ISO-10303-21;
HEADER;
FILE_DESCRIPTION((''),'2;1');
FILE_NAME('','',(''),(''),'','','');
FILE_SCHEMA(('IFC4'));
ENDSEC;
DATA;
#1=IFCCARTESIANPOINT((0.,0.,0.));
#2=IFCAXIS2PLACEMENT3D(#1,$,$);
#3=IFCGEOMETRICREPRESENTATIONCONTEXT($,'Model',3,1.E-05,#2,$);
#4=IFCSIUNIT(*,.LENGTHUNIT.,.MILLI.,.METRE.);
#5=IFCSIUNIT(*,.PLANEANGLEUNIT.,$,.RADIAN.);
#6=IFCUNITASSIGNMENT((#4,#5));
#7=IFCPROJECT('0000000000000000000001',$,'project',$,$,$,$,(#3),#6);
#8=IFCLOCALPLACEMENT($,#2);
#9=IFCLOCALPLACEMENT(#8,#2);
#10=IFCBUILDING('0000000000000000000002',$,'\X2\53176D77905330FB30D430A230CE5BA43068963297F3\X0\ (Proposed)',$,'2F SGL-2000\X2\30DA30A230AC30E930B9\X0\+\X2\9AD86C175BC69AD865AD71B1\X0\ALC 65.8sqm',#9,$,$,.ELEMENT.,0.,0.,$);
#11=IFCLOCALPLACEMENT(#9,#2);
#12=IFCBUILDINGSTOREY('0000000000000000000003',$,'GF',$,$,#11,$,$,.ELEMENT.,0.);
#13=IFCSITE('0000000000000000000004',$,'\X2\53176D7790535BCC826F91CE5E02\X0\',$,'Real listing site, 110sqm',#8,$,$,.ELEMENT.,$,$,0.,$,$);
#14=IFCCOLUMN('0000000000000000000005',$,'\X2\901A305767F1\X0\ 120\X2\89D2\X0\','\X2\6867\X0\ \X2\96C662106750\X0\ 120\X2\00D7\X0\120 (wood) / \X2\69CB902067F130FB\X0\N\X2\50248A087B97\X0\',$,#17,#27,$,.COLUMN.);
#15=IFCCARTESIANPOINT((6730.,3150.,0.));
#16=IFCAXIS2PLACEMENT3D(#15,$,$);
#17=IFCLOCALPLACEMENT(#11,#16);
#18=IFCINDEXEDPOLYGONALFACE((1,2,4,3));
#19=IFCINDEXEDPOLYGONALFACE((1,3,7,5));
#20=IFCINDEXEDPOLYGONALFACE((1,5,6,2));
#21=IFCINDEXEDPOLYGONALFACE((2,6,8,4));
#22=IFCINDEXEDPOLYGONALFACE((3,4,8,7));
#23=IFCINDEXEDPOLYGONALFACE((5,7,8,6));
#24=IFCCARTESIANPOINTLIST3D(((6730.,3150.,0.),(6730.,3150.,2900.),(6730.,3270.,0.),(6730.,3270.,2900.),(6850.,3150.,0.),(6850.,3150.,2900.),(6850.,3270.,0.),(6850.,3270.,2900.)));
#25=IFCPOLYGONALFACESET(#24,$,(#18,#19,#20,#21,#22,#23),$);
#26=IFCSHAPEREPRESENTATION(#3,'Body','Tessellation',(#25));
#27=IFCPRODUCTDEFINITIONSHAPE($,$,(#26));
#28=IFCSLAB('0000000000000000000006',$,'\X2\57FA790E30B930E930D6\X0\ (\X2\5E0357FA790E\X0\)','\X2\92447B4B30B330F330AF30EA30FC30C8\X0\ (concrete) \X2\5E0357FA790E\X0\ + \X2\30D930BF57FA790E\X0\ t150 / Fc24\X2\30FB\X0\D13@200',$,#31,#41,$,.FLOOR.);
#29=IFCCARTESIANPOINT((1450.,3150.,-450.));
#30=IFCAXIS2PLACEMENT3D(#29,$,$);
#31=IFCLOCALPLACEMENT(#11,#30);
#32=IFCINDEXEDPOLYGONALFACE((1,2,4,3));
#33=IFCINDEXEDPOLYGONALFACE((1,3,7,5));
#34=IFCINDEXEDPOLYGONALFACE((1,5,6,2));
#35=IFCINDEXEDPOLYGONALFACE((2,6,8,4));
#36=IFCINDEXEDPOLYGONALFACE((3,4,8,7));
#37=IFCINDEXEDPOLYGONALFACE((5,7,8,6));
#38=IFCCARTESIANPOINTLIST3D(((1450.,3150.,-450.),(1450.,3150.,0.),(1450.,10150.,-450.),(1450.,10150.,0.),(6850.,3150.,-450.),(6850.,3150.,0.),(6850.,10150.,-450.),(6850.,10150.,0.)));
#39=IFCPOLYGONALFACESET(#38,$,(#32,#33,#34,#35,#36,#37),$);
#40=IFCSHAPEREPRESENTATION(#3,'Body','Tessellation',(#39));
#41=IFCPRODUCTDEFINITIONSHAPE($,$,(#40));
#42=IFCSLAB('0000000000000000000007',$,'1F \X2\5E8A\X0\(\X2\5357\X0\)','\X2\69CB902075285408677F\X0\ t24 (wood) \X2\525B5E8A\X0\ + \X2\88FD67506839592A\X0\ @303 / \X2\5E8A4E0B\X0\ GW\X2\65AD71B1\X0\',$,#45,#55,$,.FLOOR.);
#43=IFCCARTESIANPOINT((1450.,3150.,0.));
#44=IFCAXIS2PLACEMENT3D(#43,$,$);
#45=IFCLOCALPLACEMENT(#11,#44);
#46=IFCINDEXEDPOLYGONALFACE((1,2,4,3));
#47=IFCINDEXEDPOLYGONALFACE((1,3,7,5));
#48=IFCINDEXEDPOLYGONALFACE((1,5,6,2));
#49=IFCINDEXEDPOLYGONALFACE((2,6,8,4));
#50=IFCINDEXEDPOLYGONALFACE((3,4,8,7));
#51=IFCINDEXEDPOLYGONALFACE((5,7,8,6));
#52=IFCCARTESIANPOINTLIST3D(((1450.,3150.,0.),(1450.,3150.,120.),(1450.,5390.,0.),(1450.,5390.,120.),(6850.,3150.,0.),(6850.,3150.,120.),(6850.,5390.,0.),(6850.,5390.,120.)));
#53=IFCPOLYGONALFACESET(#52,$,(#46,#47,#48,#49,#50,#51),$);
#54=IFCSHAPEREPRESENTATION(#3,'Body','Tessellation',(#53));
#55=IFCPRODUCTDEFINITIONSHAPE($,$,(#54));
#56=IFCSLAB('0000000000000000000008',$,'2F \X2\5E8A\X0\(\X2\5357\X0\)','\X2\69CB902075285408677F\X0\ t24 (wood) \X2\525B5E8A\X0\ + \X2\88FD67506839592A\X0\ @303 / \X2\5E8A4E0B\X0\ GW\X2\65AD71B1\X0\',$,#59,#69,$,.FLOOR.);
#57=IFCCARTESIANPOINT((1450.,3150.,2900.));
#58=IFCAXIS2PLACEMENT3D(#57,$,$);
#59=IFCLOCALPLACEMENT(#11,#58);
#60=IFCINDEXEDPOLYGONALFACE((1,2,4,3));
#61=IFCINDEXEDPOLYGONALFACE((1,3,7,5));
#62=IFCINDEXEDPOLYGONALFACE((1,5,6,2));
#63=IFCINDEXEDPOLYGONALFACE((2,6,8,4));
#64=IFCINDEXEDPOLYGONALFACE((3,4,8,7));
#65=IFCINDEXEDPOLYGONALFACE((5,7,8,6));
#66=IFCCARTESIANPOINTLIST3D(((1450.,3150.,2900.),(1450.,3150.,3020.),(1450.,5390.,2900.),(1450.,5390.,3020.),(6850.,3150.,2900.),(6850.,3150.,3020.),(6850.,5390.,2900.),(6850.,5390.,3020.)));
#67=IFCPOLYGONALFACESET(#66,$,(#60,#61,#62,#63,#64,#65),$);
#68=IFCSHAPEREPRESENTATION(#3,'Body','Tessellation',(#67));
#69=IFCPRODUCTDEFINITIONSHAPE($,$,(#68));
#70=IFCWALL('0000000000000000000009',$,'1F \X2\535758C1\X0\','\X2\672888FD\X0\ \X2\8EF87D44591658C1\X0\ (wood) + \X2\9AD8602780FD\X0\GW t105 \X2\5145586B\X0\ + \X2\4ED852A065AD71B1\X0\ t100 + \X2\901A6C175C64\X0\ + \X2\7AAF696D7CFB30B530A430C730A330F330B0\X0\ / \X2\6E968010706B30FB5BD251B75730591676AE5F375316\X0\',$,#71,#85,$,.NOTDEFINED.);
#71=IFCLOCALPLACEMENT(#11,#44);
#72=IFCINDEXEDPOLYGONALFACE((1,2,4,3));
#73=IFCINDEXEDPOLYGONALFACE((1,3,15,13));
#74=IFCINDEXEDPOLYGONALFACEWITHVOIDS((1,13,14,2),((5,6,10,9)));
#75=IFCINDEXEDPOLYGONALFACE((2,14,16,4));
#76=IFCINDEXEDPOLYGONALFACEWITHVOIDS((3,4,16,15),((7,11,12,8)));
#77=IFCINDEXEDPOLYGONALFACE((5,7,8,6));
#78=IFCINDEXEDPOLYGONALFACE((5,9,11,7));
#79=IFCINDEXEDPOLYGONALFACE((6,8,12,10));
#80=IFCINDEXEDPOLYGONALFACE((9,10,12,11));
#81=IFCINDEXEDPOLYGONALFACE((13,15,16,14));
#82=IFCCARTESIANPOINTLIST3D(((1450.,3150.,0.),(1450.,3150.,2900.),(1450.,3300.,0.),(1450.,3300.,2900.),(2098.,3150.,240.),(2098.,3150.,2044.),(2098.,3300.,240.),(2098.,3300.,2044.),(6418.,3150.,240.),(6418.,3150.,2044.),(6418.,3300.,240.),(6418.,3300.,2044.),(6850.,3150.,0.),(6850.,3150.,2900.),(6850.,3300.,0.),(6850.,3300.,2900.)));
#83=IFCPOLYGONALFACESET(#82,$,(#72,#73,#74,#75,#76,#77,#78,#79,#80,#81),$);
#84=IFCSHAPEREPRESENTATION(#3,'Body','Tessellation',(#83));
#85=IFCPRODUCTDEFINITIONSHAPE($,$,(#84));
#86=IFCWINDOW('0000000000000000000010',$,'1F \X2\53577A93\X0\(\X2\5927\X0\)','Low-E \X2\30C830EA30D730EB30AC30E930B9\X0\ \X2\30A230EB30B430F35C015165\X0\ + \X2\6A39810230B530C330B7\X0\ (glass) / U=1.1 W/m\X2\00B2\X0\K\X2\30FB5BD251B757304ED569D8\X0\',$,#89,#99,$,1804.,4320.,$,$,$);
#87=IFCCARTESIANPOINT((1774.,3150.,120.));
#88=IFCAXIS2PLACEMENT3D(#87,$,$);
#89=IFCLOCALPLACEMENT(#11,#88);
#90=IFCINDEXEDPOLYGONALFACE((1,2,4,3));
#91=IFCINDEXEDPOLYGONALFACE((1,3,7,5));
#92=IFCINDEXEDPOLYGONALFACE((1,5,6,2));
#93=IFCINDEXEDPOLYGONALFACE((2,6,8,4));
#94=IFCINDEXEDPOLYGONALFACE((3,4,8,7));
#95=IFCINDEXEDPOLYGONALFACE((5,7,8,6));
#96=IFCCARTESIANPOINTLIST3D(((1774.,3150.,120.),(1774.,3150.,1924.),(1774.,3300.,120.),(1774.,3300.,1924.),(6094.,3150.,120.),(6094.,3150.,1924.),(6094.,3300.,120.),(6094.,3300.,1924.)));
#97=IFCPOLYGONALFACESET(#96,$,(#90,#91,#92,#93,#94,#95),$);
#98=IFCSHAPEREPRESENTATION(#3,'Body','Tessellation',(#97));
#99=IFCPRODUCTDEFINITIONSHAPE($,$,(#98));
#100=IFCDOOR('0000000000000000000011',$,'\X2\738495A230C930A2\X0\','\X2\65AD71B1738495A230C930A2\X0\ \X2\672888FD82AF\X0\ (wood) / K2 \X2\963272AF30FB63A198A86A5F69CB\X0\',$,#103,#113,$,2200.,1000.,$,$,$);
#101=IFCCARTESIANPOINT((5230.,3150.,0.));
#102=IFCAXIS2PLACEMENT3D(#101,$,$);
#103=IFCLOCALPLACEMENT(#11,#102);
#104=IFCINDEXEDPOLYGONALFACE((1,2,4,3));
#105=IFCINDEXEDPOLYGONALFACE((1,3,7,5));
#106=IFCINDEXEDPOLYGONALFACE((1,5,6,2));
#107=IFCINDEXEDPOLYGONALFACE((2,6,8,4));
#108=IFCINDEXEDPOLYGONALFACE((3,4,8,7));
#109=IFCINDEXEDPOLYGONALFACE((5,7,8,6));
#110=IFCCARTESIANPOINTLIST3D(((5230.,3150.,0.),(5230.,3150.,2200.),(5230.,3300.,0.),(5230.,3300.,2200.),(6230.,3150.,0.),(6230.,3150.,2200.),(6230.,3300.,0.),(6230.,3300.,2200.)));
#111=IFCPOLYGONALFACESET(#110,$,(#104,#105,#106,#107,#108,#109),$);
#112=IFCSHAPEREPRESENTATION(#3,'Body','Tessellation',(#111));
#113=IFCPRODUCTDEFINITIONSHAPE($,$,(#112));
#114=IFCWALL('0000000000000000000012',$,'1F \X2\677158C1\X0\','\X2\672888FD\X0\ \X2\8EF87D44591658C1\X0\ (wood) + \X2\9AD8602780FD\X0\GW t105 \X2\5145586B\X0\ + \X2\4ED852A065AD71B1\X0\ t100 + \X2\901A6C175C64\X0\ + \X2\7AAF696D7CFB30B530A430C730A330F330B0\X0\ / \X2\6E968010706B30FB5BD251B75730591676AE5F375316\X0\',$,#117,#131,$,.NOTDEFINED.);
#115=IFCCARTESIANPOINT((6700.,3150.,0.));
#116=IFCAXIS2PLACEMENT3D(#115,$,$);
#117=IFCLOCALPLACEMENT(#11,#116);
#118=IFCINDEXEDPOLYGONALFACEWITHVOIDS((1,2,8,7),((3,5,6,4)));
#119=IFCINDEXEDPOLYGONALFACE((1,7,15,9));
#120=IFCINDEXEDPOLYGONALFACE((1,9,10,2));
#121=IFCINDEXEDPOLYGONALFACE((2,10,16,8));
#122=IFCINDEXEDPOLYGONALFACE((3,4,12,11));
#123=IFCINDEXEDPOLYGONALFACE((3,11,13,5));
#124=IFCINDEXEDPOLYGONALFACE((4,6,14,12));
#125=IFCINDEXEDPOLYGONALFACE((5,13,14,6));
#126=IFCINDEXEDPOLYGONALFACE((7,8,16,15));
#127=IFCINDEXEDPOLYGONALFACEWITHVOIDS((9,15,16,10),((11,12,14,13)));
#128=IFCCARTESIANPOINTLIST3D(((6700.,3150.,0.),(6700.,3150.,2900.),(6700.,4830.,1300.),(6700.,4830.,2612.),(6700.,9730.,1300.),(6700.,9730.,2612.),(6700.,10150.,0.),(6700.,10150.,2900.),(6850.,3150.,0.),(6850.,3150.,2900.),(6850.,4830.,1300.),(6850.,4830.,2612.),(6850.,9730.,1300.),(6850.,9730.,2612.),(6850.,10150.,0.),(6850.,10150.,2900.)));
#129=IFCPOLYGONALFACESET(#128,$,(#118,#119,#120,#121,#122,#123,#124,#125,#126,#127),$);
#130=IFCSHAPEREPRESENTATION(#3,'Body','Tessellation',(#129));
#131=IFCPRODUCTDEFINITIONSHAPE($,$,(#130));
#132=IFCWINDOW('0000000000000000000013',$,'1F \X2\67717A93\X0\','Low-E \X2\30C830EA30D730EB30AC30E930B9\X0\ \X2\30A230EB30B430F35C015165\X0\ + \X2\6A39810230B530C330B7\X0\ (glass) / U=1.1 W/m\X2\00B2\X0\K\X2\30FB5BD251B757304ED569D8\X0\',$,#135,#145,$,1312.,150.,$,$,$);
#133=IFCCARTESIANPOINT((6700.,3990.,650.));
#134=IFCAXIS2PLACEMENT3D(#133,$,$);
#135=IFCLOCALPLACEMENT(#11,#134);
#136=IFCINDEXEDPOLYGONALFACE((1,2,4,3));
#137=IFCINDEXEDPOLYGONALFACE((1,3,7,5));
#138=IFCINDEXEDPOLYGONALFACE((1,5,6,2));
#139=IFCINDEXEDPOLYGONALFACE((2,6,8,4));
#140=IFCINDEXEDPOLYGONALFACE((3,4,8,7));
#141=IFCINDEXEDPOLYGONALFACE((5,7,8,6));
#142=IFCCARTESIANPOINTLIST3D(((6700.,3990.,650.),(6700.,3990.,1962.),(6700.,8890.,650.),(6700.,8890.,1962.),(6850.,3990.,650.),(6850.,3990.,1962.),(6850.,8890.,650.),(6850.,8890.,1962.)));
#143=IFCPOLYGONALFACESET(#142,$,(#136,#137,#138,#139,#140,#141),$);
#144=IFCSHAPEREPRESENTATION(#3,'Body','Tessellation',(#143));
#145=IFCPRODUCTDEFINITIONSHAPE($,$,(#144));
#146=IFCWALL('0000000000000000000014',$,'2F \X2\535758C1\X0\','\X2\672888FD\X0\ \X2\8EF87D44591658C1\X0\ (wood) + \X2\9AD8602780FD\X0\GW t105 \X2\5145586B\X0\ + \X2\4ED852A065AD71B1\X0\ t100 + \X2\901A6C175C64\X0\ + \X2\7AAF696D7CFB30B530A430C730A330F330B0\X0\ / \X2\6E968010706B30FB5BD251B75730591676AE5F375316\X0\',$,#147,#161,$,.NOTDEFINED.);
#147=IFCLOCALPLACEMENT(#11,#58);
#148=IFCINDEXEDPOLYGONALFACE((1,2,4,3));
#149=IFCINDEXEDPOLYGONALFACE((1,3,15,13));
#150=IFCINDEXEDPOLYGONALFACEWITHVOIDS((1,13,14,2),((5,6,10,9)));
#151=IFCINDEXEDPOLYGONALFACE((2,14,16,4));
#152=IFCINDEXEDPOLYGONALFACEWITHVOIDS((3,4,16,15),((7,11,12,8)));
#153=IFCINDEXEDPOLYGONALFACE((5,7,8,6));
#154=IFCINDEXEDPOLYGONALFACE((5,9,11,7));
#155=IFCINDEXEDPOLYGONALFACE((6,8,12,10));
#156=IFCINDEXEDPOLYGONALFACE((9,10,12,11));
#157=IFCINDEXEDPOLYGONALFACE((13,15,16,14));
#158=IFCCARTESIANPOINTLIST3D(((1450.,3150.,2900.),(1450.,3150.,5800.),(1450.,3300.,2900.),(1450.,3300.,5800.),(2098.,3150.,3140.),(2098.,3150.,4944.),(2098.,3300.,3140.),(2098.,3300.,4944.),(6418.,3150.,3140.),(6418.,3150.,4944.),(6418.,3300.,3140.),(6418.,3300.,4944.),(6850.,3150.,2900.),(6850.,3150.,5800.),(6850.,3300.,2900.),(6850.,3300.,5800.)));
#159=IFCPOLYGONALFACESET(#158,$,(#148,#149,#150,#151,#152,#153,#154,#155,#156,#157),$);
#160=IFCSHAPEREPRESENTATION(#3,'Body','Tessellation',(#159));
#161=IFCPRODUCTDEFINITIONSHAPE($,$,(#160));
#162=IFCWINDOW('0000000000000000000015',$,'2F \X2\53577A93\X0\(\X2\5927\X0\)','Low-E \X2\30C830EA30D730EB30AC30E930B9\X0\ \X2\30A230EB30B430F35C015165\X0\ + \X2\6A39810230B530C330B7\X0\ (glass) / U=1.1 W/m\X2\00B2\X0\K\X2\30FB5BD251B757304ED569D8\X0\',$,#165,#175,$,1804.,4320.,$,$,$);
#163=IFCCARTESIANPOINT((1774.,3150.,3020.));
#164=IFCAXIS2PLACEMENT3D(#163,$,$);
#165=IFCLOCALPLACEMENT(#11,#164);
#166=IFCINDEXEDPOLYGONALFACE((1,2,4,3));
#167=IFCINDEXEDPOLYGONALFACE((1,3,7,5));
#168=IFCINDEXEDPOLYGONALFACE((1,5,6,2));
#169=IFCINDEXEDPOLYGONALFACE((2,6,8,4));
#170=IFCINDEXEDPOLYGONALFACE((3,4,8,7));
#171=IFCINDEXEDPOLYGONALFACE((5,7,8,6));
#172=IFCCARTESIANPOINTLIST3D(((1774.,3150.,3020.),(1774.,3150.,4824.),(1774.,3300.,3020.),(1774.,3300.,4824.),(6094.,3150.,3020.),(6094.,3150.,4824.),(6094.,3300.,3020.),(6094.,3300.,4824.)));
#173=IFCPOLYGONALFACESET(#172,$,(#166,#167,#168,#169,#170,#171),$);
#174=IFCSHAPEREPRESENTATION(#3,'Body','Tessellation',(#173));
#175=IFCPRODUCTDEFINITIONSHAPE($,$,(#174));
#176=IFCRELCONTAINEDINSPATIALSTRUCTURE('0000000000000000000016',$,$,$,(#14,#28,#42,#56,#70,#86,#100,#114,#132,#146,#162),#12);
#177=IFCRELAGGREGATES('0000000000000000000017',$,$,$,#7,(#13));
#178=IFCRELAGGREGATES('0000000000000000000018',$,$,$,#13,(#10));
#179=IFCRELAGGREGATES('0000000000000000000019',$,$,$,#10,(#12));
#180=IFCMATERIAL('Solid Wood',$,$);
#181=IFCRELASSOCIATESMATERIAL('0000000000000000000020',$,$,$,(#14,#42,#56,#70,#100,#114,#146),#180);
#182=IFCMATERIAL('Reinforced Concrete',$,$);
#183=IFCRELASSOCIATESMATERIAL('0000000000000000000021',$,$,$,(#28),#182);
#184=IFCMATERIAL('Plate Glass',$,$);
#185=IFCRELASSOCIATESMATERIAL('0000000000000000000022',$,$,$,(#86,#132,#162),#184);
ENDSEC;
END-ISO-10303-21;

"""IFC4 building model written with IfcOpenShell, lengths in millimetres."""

from ifc_helpers import new_model, si_unit, frame, frame_2d, origin, place, context, project, spatial, rectangle, extrude, material, element, fill, save


model = new_model("IFC4")

# Units and contexts
model_context = context("Model", 3, precision=1e-05, world=origin())
ifc_project = project(units=[si_unit("LENGTHUNIT", "METRE", prefix="MILLI"), si_unit("PLANEANGLEUNIT", "RADIAN")], contexts=[model_context])

# Site, building, storey
site_placement = place(None, origin())
site = spatial("IfcSite", under=ifc_project, at=site_placement, Name="北海道富良野市", ObjectType="Real listing site, 110sqm", CompositionType="ELEMENT", RefElevation=0.0)
building_placement = place(site_placement, origin())
building = spatial("IfcBuilding", under=site, at=building_placement, Name="北海道・ピアノ室と防音 (Proposed)", ObjectType="2F SGL-2000ペアガラス+高気密高断熱ALC 65.8sqm", CompositionType="ELEMENT", ElevationOfRefHeight=0.0, ElevationOfTerrain=0.0)
storey_placement = place(building_placement, origin())
storey = spatial("IfcBuildingStorey", under=building, at=storey_placement, Name="GF", CompositionType="ELEMENT", Elevation=0.0)

# Column
ifc_material_1 = material(Name="Solid Wood")
column_1_placement = place(storey_placement, frame((6730.0, 3150.0, 0.0)))
element("IfcColumn", 1, at=column_1_placement, inside=storey, material=ifc_material_1, Name="通し柱 120角", Description="桧 集成材 120×120 (wood) / 構造柱・N値計算", PredefinedType="COLUMN", context=model_context, shape_type="SweptSolid", body=[
    extrude(rectangle(XDim=120.0, YDim=120.0, at=frame_2d((60.0, 60.0))), frame((6730.0, 3150.0, 0.0)), (0.0, 0.0, 1.0), 2900.0),
])

# Slabs
ifc_material_2 = material(Name="Reinforced Concrete")
slab_1_placement = place(storey_placement, frame((1450.0, 3150.0, -450.0)))
element("IfcSlab", 2, at=slab_1_placement, inside=storey, material=ifc_material_2, Name="基礎スラブ (布基礎)", Description="鉄筋コンクリート (concrete) 布基礎 + ベタ基礎 t150 / Fc24・D13@200", PredefinedType="FLOOR", context=model_context, shape_type="SweptSolid", body=[
    extrude(rectangle(XDim=5400.0, YDim=7000.0, at=frame_2d((2700.0, 3500.0))), frame((1450.0, 3150.0, -450.0)), (0.0, 0.0, 1.0), 450.0),
])
slab_2_placement = place(storey_placement, frame((1450.0, 3150.0, 0.0)))
element("IfcSlab", 3, at=slab_2_placement, inside=storey, material=ifc_material_1, Name="1F 床(南)", Description="構造用合板 t24 (wood) 剛床 + 製材根太 @303 / 床下 GW断熱", PredefinedType="FLOOR", context=model_context, shape_type="SweptSolid", body=[
    extrude(rectangle(XDim=5400.0, YDim=2240.0, at=frame_2d((2700.0, 1120.0))), frame((1450.0, 3150.0, 0.0)), (0.0, 0.0, 1.0), 120.0),
])
slab_3_placement = place(storey_placement, frame((1450.0, 3150.0, 2900.0)))
element("IfcSlab", 4, at=slab_3_placement, inside=storey, material=ifc_material_1, Name="2F 床(南)", Description="構造用合板 t24 (wood) 剛床 + 製材根太 @303 / 床下 GW断熱", PredefinedType="FLOOR", context=model_context, shape_type="SweptSolid", body=[
    extrude(rectangle(XDim=5400.0, YDim=2240.0, at=frame_2d((2700.0, 1120.0))), frame((1450.0, 3150.0, 2900.0)), (0.0, 0.0, 1.0), 120.0),
])

# Wall, openings, window, door
wall_1_placement = place(storey_placement, frame((1450.0, 3150.0, 0.0)))
wall_1 = element("IfcWall", 5, at=wall_1_placement, inside=storey, material=ifc_material_1, Name="1F 南壁", Description="木製 軸組外壁 (wood) + 高性能GW t105 充填 + 付加断熱 t100 + 通気層 + 窯業系サイディング / 準耐火・寒冷地外皮強化", PredefinedType="NOTDEFINED", context=model_context, shape_type="SweptSolid", body=[
    extrude(rectangle(XDim=5400.0, YDim=150.0, at=frame_2d((2700.0, 75.0))), frame((1450.0, 3150.0, 0.0)), (0.0, 0.0, 1.0), 2900.0),
])
opening_1_placement = place(storey_placement, frame((1774.0, 3150.0, 120.0)))
opening_1 = element("IfcOpeningElement", 6, at=opening_1_placement, cuts=wall_1, PredefinedType="NOTDEFINED", context=model_context, shape_type="SweptSolid", body=[
    extrude(rectangle(XDim=4320.0, YDim=150.0, at=frame_2d((2160.0, 75.0))), frame((1774.0, 3150.0, 120.0)), (0.0, 0.0, 1.0), 1804.0),
])
opening_2_placement = place(storey_placement, frame((5230.0, 3150.0, 0.0)))
opening_2 = element("IfcOpeningElement", 7, at=opening_2_placement, cuts=wall_1, PredefinedType="NOTDEFINED", context=model_context, shape_type="SweptSolid", body=[
    extrude(rectangle(XDim=1000.0, YDim=150.0, at=frame_2d((500.0, 75.0))), frame((5230.0, 3150.0, 0.0)), (0.0, 0.0, 1.0), 2200.0),
])
ifc_material_3 = material(Name="Plate Glass")
window_1_placement = place(storey_placement, frame((1774.0, 3150.0, 120.0)))
window_1 = element("IfcWindow", 8, at=window_1_placement, inside=storey, material=ifc_material_3, Name="1F 南窓(大)", Description="Low-E トリプルガラス アルゴン封入 + 樹脂サッシ (glass) / U=1.1 W/m²K・寒冷地仕様", OverallHeight=1804.0, OverallWidth=4320.0, context=model_context, shape_type="SweptSolid", body=[
    extrude(rectangle(XDim=4320.0, YDim=150.0, at=frame_2d((2160.0, 75.0))), frame((1774.0, 3150.0, 120.0)), (0.0, 0.0, 1.0), 1804.0),
])
fill(opening_1, window_1)
door_placement = place(storey_placement, frame((5230.0, 3150.0, 0.0)))
door = element("IfcDoor", 9, at=door_placement, inside=storey, material=ifc_material_1, Name="玄関ドア", Description="断熱玄関ドア 木製芯 (wood) / K2 防犯・採風機構", OverallHeight=2200.0, OverallWidth=1000.0, context=model_context, shape_type="SweptSolid", body=[
    extrude(rectangle(XDim=1000.0, YDim=150.0, at=frame_2d((500.0, 75.0))), frame((5230.0, 3150.0, 0.0)), (0.0, 0.0, 1.0), 2200.0),
])
fill(opening_2, door)

# Walls, openings, windows
wall_2_placement = place(storey_placement, frame((6700.0, 3150.0, 0.0)))
wall_2 = element("IfcWall", 10, at=wall_2_placement, inside=storey, material=ifc_material_1, Name="1F 東壁", Description="木製 軸組外壁 (wood) + 高性能GW t105 充填 + 付加断熱 t100 + 通気層 + 窯業系サイディング / 準耐火・寒冷地外皮強化", PredefinedType="NOTDEFINED", context=model_context, shape_type="SweptSolid", body=[
    extrude(rectangle(XDim=150.0, YDim=7000.0, at=frame_2d((75.0, 3500.0))), frame((6700.0, 3150.0, 0.0)), (0.0, 0.0, 1.0), 2900.0),
])
opening_3_placement = place(storey_placement, frame((6700.0, 3990.0, 650.0)))
opening_3 = element("IfcOpeningElement", 11, at=opening_3_placement, cuts=wall_2, PredefinedType="NOTDEFINED", context=model_context, shape_type="SweptSolid", body=[
    extrude(rectangle(XDim=150.0, YDim=4900.0, at=frame_2d((75.0, 2450.0))), frame((6700.0, 3990.0, 650.0)), (0.0, 0.0, 1.0), 1312.0),
])
window_2_placement = place(storey_placement, frame((6700.0, 3990.0, 650.0)))
window_2 = element("IfcWindow", 12, at=window_2_placement, inside=storey, material=ifc_material_3, Name="1F 東窓", Description="Low-E トリプルガラス アルゴン封入 + 樹脂サッシ (glass) / U=1.1 W/m²K・寒冷地仕様", OverallHeight=1312.0, OverallWidth=150.0, context=model_context, shape_type="SweptSolid", body=[
    extrude(rectangle(XDim=150.0, YDim=4900.0, at=frame_2d((75.0, 2450.0))), frame((6700.0, 3990.0, 650.0)), (0.0, 0.0, 1.0), 1312.0),
])
fill(opening_3, window_2)
wall_3_placement = place(storey_placement, frame((1450.0, 3150.0, 2900.0)))
wall_3 = element("IfcWall", 13, at=wall_3_placement, inside=storey, material=ifc_material_1, Name="2F 南壁", Description="木製 軸組外壁 (wood) + 高性能GW t105 充填 + 付加断熱 t100 + 通気層 + 窯業系サイディング / 準耐火・寒冷地外皮強化", PredefinedType="NOTDEFINED", context=model_context, shape_type="SweptSolid", body=[
    extrude(rectangle(XDim=5400.0, YDim=150.0, at=frame_2d((2700.0, 75.0))), frame((1450.0, 3150.0, 2900.0)), (0.0, 0.0, 1.0), 2900.0),
])
opening_4_placement = place(storey_placement, frame((1774.0, 3150.0, 3020.0)))
opening_4 = element("IfcOpeningElement", 14, at=opening_4_placement, cuts=wall_3, PredefinedType="NOTDEFINED", context=model_context, shape_type="SweptSolid", body=[
    extrude(rectangle(XDim=4320.0, YDim=150.0, at=frame_2d((2160.0, 75.0))), frame((1774.0, 3150.0, 3020.0)), (0.0, 0.0, 1.0), 1804.0),
])
window_3_placement = place(storey_placement, frame((1774.0, 3150.0, 3020.0)))
window_3 = element("IfcWindow", 15, at=window_3_placement, inside=storey, material=ifc_material_3, Name="2F 南窓(大)", Description="Low-E トリプルガラス アルゴン封入 + 樹脂サッシ (glass) / U=1.1 W/m²K・寒冷地仕様", OverallHeight=1804.0, OverallWidth=4320.0, context=model_context, shape_type="SweptSolid", body=[
    extrude(rectangle(XDim=4320.0, YDim=150.0, at=frame_2d((2160.0, 75.0))), frame((1774.0, 3150.0, 3020.0)), (0.0, 0.0, 1.0), 1804.0),
])
fill(opening_4, window_3)

save(model, "model.ifc")
